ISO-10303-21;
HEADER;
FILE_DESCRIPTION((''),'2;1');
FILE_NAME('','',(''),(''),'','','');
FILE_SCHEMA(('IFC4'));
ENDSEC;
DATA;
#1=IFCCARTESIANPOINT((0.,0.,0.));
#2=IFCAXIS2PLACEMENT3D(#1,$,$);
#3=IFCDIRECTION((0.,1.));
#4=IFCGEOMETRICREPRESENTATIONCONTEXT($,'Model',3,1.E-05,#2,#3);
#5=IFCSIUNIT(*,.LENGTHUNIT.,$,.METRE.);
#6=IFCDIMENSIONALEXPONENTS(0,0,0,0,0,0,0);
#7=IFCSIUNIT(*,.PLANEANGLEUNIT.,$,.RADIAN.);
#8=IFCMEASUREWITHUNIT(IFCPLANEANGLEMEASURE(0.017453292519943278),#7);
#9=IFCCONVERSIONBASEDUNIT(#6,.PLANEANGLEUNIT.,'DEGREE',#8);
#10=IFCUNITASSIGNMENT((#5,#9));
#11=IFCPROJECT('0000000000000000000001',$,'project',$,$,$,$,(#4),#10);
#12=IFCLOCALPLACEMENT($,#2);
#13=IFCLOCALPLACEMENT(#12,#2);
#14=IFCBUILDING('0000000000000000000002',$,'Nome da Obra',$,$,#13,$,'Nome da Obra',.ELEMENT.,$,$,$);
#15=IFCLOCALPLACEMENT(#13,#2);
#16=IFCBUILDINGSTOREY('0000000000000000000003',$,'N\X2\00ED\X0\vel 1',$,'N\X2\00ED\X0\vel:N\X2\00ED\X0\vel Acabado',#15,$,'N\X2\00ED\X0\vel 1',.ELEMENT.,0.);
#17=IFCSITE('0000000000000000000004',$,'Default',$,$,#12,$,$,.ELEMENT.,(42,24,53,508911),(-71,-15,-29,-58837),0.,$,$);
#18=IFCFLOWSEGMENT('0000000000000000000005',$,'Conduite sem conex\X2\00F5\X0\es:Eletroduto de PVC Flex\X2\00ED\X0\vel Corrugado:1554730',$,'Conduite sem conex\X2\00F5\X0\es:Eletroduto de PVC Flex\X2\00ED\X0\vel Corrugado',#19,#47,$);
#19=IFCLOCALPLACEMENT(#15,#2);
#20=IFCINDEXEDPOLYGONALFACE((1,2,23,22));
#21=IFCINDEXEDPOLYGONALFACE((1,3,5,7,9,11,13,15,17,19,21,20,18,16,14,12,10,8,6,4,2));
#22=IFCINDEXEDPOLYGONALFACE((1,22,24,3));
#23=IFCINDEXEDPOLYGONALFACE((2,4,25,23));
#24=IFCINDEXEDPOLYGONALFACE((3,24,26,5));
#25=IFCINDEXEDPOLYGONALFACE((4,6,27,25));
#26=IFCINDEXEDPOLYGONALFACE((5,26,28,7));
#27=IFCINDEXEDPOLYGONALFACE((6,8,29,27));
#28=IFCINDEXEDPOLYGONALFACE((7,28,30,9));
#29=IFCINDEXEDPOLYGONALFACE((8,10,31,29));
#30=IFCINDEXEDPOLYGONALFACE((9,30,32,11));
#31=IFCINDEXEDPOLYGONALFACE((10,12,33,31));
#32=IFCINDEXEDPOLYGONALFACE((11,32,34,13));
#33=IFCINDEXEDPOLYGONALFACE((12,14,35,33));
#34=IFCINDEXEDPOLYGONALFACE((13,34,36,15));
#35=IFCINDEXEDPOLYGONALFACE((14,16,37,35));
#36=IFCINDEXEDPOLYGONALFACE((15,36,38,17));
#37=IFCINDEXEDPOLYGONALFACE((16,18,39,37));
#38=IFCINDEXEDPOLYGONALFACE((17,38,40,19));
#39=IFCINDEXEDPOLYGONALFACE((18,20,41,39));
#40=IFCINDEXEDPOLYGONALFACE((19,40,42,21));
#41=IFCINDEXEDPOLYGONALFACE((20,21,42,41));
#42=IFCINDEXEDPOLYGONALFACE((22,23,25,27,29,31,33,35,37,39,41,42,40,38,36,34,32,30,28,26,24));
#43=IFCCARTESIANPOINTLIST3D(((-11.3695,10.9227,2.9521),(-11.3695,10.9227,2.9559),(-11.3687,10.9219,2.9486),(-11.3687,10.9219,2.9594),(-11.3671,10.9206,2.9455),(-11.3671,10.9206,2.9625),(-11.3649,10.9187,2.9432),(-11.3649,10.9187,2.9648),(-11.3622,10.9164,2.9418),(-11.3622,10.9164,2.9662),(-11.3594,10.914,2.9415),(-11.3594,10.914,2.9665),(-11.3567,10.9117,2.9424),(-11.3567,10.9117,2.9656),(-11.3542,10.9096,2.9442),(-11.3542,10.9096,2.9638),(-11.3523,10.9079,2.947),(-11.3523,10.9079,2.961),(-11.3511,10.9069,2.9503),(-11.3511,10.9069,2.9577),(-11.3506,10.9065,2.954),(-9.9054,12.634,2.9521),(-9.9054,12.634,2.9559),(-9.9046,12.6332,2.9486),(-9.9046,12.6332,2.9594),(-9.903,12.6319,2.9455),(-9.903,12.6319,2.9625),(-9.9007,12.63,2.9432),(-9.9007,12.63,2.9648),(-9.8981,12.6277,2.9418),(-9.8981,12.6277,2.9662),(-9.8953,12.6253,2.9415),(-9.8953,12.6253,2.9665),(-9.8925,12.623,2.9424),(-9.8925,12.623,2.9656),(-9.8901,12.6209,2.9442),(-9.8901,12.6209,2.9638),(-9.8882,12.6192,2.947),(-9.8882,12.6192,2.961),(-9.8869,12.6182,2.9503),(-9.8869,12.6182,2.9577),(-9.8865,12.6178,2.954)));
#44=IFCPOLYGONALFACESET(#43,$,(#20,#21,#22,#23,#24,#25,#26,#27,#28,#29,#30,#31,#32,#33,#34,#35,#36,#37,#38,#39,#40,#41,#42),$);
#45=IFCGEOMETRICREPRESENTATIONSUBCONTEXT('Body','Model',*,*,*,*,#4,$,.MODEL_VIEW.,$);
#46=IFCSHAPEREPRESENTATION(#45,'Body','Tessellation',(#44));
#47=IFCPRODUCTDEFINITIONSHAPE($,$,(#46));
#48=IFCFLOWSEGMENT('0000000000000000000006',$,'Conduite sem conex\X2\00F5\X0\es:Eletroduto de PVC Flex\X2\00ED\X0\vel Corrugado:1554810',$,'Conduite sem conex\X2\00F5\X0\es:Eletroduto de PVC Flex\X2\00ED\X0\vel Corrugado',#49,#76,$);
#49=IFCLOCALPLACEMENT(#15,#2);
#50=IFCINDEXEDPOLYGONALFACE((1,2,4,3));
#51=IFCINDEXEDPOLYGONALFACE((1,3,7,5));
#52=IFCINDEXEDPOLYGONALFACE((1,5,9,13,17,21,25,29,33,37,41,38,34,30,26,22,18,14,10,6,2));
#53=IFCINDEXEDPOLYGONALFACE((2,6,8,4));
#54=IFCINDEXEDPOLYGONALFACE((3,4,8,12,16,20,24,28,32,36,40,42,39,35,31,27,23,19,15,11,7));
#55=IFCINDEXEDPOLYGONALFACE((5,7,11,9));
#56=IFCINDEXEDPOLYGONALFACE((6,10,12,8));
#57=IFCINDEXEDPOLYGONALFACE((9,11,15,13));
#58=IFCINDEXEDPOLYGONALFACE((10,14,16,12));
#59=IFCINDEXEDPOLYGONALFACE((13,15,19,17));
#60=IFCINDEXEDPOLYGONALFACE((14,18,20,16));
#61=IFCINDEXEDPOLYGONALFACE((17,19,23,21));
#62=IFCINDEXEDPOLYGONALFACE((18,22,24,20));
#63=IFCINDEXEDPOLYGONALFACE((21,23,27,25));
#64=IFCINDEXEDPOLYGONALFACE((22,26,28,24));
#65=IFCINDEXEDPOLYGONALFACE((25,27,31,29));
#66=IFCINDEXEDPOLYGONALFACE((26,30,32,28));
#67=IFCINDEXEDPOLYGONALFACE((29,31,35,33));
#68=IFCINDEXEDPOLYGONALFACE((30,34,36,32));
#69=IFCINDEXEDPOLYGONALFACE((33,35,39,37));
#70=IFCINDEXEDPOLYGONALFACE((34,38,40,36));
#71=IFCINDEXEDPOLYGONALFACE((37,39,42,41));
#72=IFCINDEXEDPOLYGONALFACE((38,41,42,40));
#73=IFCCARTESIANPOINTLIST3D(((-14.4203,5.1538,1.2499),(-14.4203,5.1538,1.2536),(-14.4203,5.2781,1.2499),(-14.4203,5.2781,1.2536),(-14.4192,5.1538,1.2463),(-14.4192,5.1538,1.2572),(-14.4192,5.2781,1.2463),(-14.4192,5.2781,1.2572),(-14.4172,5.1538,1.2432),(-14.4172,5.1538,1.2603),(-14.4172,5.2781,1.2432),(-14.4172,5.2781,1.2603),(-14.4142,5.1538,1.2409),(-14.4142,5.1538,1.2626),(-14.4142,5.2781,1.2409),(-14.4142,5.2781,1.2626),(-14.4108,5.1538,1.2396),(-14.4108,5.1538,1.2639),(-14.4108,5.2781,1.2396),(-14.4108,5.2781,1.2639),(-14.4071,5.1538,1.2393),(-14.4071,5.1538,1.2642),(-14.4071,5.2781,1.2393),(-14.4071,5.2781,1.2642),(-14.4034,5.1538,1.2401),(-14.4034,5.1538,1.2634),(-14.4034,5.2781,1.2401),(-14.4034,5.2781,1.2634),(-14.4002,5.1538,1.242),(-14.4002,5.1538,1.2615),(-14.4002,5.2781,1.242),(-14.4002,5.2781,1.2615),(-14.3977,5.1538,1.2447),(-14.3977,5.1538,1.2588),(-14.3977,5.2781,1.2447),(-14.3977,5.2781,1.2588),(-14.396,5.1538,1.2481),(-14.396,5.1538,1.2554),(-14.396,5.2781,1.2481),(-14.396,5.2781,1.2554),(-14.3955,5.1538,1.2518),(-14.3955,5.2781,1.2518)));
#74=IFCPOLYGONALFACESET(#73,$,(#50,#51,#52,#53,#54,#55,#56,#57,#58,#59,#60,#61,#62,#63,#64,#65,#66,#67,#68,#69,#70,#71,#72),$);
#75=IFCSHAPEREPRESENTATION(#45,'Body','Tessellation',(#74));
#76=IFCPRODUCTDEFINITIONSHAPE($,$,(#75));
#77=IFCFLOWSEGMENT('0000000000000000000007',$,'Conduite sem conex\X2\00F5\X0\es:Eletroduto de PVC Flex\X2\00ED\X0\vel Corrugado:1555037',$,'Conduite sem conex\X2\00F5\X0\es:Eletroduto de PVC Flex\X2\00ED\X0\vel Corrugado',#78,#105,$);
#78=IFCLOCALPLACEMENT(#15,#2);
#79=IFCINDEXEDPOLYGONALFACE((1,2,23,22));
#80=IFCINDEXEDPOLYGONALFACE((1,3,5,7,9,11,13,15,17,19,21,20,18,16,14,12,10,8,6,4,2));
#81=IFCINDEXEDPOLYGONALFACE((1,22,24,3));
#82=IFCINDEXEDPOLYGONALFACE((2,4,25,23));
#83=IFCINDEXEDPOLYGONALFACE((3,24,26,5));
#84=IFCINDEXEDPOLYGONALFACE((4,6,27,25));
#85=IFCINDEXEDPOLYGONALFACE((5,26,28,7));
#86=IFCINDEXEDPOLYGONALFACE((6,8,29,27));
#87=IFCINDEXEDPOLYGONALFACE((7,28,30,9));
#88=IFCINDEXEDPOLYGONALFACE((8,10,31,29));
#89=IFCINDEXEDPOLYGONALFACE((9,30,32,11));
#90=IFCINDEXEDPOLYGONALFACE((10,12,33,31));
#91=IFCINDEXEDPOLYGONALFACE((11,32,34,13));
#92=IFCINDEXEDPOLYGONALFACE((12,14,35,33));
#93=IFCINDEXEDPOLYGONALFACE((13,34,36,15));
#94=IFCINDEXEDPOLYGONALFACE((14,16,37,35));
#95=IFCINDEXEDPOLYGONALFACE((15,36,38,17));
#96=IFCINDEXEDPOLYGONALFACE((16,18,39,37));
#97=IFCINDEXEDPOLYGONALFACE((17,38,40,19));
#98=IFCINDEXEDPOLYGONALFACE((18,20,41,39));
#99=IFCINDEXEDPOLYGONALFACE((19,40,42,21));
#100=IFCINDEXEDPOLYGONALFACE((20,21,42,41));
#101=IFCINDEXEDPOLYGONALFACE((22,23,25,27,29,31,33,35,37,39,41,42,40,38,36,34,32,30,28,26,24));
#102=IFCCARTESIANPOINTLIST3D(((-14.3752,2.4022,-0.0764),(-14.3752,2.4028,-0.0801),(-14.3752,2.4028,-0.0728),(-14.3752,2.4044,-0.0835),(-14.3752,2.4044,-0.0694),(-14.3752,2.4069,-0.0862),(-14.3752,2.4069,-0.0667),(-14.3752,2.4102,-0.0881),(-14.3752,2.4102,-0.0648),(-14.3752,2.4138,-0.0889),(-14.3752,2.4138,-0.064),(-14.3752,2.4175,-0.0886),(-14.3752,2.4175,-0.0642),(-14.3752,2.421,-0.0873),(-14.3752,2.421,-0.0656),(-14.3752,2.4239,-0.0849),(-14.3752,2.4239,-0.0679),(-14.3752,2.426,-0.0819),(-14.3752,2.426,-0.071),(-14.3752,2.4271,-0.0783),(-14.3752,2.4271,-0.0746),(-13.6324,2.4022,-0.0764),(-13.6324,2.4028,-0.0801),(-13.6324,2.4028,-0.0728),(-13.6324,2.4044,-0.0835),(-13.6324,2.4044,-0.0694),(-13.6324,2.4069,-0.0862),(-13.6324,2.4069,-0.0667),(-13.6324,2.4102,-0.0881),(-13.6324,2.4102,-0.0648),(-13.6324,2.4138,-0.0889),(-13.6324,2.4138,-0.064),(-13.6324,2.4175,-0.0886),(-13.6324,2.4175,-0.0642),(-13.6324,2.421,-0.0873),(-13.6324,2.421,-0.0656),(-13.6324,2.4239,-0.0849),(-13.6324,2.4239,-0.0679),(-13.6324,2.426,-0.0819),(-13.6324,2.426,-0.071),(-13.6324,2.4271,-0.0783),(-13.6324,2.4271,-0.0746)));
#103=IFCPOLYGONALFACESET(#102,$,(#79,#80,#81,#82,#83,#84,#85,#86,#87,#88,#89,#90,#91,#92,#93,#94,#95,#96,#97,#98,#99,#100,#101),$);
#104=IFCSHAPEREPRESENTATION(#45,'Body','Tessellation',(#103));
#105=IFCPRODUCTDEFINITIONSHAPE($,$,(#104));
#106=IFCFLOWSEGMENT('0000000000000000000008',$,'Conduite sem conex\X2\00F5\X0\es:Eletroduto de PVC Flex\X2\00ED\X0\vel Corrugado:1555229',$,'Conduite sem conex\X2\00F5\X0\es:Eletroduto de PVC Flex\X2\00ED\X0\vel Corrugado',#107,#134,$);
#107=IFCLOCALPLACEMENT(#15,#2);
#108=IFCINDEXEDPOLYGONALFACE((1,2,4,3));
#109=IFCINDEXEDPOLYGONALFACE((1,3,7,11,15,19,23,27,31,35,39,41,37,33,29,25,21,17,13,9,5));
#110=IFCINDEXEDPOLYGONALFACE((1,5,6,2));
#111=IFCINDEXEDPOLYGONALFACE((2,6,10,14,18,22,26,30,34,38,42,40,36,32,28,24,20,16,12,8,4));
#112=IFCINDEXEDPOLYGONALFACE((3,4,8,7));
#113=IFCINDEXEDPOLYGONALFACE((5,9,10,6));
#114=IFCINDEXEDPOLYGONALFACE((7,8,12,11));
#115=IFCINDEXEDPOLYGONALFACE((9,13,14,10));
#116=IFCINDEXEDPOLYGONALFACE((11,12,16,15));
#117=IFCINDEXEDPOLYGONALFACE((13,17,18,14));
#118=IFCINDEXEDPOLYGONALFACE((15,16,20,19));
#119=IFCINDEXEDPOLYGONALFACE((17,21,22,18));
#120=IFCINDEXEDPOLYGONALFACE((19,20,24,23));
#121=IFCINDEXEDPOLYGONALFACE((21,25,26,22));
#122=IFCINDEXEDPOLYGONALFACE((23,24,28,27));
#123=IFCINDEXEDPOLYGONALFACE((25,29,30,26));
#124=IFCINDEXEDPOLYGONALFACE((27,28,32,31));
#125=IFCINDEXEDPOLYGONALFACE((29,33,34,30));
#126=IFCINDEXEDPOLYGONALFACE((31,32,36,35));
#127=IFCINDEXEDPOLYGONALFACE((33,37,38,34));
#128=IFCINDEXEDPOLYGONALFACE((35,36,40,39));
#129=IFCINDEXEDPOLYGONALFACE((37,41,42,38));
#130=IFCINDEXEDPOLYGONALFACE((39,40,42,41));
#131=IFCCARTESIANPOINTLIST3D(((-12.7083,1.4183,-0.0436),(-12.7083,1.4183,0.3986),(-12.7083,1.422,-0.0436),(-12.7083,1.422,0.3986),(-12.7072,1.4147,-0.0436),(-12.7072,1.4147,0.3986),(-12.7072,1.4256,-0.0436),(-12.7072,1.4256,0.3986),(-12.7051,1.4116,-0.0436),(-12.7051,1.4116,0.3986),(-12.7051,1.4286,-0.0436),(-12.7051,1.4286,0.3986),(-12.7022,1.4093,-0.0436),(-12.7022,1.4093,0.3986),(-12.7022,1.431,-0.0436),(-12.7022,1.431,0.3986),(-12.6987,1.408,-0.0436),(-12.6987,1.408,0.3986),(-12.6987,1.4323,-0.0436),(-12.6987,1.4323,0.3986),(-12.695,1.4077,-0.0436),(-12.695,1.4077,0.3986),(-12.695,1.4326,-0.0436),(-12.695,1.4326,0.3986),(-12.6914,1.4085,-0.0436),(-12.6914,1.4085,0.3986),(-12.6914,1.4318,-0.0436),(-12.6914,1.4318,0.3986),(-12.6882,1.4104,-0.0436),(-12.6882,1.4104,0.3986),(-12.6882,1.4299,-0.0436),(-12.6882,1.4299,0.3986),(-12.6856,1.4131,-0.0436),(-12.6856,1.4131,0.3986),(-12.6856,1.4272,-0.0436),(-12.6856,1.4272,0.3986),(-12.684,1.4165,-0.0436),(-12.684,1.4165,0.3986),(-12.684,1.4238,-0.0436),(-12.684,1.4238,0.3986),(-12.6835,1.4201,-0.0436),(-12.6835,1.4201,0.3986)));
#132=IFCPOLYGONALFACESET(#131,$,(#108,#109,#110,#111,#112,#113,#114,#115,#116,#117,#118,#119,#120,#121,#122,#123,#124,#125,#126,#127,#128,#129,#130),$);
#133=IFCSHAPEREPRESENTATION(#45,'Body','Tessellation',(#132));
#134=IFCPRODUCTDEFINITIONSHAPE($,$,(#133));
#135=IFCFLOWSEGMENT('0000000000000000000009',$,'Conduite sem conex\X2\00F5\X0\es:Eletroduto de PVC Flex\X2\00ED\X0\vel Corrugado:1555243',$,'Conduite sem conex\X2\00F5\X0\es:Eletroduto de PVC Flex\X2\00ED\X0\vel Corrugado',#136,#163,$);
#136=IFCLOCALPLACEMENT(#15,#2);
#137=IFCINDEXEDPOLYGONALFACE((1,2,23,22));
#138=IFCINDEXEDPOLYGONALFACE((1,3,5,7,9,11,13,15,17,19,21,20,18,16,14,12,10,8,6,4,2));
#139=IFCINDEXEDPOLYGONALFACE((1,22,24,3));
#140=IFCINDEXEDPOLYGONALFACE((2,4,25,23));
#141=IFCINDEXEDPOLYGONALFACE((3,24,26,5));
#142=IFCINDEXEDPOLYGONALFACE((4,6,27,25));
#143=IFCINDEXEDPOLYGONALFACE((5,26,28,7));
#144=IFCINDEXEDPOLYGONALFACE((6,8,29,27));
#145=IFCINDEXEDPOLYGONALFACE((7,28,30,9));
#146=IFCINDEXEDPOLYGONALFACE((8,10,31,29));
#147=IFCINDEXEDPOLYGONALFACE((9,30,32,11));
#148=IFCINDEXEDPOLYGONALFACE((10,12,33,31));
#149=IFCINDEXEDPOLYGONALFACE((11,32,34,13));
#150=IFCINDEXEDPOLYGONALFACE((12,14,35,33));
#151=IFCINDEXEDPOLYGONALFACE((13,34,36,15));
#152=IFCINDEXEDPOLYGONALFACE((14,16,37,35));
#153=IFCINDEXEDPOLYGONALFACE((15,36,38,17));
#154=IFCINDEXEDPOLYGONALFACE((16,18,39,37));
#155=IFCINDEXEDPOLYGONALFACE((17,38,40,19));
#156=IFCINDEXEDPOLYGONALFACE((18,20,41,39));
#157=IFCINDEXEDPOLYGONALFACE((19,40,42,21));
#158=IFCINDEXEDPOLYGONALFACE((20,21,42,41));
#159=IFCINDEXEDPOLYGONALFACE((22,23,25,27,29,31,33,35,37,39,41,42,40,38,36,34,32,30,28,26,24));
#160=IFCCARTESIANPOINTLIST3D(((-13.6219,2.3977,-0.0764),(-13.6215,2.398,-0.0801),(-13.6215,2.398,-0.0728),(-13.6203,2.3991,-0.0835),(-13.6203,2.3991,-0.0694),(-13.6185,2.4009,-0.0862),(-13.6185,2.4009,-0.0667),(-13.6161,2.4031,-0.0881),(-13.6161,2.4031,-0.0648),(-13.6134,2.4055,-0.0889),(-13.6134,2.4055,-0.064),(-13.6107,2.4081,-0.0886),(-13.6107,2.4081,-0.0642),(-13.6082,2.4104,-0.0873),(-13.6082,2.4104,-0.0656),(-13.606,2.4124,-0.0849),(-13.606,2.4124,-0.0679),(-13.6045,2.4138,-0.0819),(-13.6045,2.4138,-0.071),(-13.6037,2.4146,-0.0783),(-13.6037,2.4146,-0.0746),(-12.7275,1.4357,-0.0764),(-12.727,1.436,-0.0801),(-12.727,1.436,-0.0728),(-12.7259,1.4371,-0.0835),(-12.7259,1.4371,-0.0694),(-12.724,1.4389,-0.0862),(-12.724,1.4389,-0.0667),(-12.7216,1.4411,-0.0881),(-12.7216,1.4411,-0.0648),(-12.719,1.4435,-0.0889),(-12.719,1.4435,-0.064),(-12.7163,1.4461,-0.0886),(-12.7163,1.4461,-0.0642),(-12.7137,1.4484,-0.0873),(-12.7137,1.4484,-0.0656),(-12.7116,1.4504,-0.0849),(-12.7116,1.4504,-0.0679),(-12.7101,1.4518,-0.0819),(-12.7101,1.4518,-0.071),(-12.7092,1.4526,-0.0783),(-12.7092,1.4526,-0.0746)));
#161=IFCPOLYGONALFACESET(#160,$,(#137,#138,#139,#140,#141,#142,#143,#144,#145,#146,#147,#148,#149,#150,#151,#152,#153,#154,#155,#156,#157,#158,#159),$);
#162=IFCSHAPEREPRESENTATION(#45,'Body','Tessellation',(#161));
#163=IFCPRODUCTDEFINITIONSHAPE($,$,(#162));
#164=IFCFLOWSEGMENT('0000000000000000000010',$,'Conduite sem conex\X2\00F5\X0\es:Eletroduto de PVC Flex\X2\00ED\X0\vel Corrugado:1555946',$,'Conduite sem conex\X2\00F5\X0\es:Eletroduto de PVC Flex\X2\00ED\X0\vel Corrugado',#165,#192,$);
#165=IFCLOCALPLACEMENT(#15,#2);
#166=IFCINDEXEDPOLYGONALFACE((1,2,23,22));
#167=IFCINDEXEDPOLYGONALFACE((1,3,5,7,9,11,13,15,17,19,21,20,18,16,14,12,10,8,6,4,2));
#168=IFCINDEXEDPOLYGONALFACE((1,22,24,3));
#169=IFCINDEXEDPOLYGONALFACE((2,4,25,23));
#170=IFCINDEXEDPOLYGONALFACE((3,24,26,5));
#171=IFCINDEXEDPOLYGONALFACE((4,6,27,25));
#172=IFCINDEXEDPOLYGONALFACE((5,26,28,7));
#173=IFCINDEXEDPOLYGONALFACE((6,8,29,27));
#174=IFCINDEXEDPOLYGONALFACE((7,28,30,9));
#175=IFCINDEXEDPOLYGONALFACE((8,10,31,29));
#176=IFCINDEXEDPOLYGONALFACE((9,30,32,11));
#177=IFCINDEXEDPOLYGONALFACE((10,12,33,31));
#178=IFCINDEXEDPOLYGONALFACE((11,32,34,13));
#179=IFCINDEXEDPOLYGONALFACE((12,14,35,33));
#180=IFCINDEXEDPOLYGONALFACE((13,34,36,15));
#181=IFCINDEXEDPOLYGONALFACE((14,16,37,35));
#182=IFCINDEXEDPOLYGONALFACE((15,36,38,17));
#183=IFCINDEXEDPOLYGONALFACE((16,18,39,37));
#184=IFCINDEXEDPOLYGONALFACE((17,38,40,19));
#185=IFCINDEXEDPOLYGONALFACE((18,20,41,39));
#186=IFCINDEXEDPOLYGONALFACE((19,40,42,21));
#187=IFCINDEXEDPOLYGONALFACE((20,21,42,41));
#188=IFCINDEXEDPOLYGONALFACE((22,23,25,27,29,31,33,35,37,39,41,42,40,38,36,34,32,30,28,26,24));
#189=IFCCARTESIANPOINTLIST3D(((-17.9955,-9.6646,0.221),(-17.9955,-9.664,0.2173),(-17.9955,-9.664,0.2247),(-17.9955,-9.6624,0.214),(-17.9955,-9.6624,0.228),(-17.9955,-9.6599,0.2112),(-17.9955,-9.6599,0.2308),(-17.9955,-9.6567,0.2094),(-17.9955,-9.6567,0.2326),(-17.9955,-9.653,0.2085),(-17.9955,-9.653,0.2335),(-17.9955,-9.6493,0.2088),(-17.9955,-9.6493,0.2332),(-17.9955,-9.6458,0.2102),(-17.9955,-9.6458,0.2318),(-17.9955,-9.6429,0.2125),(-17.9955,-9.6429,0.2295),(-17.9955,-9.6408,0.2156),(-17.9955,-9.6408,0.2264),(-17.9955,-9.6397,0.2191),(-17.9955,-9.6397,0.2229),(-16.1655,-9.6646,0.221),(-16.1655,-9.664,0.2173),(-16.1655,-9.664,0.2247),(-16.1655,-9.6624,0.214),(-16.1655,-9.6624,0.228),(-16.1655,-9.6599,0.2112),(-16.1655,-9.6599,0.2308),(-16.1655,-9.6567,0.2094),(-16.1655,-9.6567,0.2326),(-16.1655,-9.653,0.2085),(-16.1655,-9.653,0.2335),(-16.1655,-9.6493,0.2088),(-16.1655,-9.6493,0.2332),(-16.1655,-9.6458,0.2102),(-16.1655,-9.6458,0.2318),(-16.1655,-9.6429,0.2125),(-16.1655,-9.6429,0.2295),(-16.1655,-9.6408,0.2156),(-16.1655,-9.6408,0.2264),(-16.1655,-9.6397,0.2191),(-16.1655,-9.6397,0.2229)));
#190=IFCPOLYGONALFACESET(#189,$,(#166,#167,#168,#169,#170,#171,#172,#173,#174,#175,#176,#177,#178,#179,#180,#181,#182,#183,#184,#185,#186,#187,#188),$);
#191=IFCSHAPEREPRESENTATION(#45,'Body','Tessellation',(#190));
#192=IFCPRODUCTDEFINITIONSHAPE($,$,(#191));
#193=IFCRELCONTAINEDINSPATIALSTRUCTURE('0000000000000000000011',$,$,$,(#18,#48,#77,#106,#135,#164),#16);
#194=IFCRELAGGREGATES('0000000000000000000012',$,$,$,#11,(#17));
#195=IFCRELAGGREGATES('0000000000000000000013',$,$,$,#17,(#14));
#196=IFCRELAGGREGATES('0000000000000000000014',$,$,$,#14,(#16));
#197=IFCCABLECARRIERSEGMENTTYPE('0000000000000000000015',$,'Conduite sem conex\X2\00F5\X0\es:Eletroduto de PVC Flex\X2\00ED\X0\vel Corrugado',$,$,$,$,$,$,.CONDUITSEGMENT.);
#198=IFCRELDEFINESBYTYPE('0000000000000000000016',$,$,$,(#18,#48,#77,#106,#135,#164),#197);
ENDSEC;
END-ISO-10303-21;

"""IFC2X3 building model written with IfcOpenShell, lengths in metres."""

from ifc_helpers import new_model, entity, si_unit, converted_unit, direction, frame, frame_2d, origin, origin_2d_with_axis, place, context, subcontext, project, spatial, circle, extrude, type_object, element, save


model = new_model("IFC2X3")

# Units and contexts
model_context = context("Model", 3, precision=1e-05, world=origin(), true_north=direction((0.0, 1.0)))
body_context = subcontext(model_context, "Body", "Model", "MODEL_VIEW")
ifc_project = project(units=[si_unit("LENGTHUNIT", "METRE"), converted_unit("PLANEANGLEUNIT", "DEGREE", entity("IfcPlaneAngleMeasure", 0.017453292519943278), si_unit("PLANEANGLEUNIT", "RADIAN"), dimensions=[0, 0, 0, 0, 0, 0, 0])], contexts=[model_context])

# Site, building, storey
site_placement = place(None, origin())
site = spatial("IfcSite", under=ifc_project, at=site_placement, Name="Default", CompositionType="ELEMENT", RefLatitude=(42, 24, 53, 508911), RefLongitude=(-71, -15, -29, -58837), RefElevation=0.0)
building_placement = place(site_placement, origin())
building = spatial("IfcBuilding", under=site, at=building_placement, Name="Nome da Obra", LongName="Nome da Obra", CompositionType="ELEMENT")
storey_placement = place(building_placement, origin())
storey = spatial("IfcBuildingStorey", under=building, at=storey_placement, Name="Nível 1", ObjectType="Nível:Nível Acabado", LongName="Nível 1", CompositionType="ELEMENT", Elevation=0.0)

# Flow segments
cable_carrier_segment_type = type_object("IfcCableCarrierSegmentType", Name="Conduite sem conexões:Eletroduto de PVC Flexível Corrugado", PredefinedType="CONDUITSEGMENT")
flow_segment_1_placement = place(storey_placement, origin())
element("IfcFlowSegment", 1, at=flow_segment_1_placement, inside=storey, type_object=cable_carrier_segment_type, Name="Conduite sem conexões:Eletroduto de PVC Flexível Corrugado:1554730", ObjectType="Conduite sem conexões:Eletroduto de PVC Flexível Corrugado", context=body_context, shape_type="SweptSolid", body=[
    extrude(circle(Radius=0.0125, at=frame_2d((0.0, 0.0), x_axis=(1.0, 0.0))), frame((-11.3601, 10.9146, 2.954), z_axis=(0.650101, 0.759848, 0.0), x_axis=(0.759848, -0.650101, 0.0)), (0.0, 0.0, 1.0), 2.2522),
])
flow_segment_2_placement = place(storey_placement, origin())
element("IfcFlowSegment", 2, at=flow_segment_2_placement, inside=storey, type_object=cable_carrier_segment_type, Name="Conduite sem conexões:Eletroduto de PVC Flexível Corrugado:1554810", ObjectType="Conduite sem conexões:Eletroduto de PVC Flexível Corrugado", context=body_context, shape_type="SweptSolid", body=[
    extrude(circle(Radius=0.0125, at=frame_2d((0.0, 0.0), x_axis=(1.0, 0.0))), frame((-14.408, 5.1538, 1.2518), z_axis=(0.0, 1.0, 0.0), x_axis=(1.0, 0.0, 0.0)), (0.0, 0.0, 1.0), 0.1243),
])
flow_segment_3_placement = place(storey_placement, origin())
element("IfcFlowSegment", 3, at=flow_segment_3_placement, inside=storey, type_object=cable_carrier_segment_type, Name="Conduite sem conexões:Eletroduto de PVC Flexível Corrugado:1555037", ObjectType="Conduite sem conexões:Eletroduto de PVC Flexível Corrugado", context=body_context, shape_type="SweptSolid", body=[
    extrude(circle(Radius=0.0125, at=origin_2d_with_axis()), frame((-14.3752, 2.4147, -0.0764), z_axis=(1.0, 0.0, 0.0), x_axis=(0.0, -1.0, 0.0)), (0.0, 0.0, 1.0), 0.7428),
])
flow_segment_4_placement = place(storey_placement, origin())
element("IfcFlowSegment", 4, at=flow_segment_4_placement, inside=storey, type_object=cable_carrier_segment_type, Name="Conduite sem conexões:Eletroduto de PVC Flexível Corrugado:1555229", ObjectType="Conduite sem conexões:Eletroduto de PVC Flexível Corrugado", context=body_context, shape_type="SweptSolid", body=[
    extrude(circle(Radius=0.0125, at=origin_2d_with_axis()), frame((-12.696, 1.4201, -0.0436)), (0.0, 0.0, 1.0), 0.4422),
])
flow_segment_5_placement = place(storey_placement, origin())
element("IfcFlowSegment", 5, at=flow_segment_5_placement, inside=storey, type_object=cable_carrier_segment_type, Name="Conduite sem conexões:Eletroduto de PVC Flexível Corrugado:1555243", ObjectType="Conduite sem conexões:Eletroduto de PVC Flexível Corrugado", context=body_context, shape_type="SweptSolid", body=[
    extrude(circle(Radius=0.0125, at=frame_2d((0.0, 0.0), x_axis=(1.0, 0.0))), frame((-13.6128, 2.4062, -0.0764), z_axis=(0.680929, -0.73235, 0.0), x_axis=(-0.73235, -0.680929, 0.0)), (0.0, 0.0, 1.0), 1.3136),
])
flow_segment_6_placement = place(storey_placement, origin())
element("IfcFlowSegment", 6, at=flow_segment_6_placement, inside=storey, type_object=cable_carrier_segment_type, Name="Conduite sem conexões:Eletroduto de PVC Flexível Corrugado:1555946", ObjectType="Conduite sem conexões:Eletroduto de PVC Flexível Corrugado", context=body_context, shape_type="SweptSolid", body=[
    extrude(circle(Radius=0.0125, at=origin_2d_with_axis()), frame((-17.9955, -9.6521, 0.221), z_axis=(1.0, 0.0, 0.0), x_axis=(0.0, -1.0, 0.0)), (0.0, 0.0, 1.0), 1.83),
])

save(model, "model.ifc")
